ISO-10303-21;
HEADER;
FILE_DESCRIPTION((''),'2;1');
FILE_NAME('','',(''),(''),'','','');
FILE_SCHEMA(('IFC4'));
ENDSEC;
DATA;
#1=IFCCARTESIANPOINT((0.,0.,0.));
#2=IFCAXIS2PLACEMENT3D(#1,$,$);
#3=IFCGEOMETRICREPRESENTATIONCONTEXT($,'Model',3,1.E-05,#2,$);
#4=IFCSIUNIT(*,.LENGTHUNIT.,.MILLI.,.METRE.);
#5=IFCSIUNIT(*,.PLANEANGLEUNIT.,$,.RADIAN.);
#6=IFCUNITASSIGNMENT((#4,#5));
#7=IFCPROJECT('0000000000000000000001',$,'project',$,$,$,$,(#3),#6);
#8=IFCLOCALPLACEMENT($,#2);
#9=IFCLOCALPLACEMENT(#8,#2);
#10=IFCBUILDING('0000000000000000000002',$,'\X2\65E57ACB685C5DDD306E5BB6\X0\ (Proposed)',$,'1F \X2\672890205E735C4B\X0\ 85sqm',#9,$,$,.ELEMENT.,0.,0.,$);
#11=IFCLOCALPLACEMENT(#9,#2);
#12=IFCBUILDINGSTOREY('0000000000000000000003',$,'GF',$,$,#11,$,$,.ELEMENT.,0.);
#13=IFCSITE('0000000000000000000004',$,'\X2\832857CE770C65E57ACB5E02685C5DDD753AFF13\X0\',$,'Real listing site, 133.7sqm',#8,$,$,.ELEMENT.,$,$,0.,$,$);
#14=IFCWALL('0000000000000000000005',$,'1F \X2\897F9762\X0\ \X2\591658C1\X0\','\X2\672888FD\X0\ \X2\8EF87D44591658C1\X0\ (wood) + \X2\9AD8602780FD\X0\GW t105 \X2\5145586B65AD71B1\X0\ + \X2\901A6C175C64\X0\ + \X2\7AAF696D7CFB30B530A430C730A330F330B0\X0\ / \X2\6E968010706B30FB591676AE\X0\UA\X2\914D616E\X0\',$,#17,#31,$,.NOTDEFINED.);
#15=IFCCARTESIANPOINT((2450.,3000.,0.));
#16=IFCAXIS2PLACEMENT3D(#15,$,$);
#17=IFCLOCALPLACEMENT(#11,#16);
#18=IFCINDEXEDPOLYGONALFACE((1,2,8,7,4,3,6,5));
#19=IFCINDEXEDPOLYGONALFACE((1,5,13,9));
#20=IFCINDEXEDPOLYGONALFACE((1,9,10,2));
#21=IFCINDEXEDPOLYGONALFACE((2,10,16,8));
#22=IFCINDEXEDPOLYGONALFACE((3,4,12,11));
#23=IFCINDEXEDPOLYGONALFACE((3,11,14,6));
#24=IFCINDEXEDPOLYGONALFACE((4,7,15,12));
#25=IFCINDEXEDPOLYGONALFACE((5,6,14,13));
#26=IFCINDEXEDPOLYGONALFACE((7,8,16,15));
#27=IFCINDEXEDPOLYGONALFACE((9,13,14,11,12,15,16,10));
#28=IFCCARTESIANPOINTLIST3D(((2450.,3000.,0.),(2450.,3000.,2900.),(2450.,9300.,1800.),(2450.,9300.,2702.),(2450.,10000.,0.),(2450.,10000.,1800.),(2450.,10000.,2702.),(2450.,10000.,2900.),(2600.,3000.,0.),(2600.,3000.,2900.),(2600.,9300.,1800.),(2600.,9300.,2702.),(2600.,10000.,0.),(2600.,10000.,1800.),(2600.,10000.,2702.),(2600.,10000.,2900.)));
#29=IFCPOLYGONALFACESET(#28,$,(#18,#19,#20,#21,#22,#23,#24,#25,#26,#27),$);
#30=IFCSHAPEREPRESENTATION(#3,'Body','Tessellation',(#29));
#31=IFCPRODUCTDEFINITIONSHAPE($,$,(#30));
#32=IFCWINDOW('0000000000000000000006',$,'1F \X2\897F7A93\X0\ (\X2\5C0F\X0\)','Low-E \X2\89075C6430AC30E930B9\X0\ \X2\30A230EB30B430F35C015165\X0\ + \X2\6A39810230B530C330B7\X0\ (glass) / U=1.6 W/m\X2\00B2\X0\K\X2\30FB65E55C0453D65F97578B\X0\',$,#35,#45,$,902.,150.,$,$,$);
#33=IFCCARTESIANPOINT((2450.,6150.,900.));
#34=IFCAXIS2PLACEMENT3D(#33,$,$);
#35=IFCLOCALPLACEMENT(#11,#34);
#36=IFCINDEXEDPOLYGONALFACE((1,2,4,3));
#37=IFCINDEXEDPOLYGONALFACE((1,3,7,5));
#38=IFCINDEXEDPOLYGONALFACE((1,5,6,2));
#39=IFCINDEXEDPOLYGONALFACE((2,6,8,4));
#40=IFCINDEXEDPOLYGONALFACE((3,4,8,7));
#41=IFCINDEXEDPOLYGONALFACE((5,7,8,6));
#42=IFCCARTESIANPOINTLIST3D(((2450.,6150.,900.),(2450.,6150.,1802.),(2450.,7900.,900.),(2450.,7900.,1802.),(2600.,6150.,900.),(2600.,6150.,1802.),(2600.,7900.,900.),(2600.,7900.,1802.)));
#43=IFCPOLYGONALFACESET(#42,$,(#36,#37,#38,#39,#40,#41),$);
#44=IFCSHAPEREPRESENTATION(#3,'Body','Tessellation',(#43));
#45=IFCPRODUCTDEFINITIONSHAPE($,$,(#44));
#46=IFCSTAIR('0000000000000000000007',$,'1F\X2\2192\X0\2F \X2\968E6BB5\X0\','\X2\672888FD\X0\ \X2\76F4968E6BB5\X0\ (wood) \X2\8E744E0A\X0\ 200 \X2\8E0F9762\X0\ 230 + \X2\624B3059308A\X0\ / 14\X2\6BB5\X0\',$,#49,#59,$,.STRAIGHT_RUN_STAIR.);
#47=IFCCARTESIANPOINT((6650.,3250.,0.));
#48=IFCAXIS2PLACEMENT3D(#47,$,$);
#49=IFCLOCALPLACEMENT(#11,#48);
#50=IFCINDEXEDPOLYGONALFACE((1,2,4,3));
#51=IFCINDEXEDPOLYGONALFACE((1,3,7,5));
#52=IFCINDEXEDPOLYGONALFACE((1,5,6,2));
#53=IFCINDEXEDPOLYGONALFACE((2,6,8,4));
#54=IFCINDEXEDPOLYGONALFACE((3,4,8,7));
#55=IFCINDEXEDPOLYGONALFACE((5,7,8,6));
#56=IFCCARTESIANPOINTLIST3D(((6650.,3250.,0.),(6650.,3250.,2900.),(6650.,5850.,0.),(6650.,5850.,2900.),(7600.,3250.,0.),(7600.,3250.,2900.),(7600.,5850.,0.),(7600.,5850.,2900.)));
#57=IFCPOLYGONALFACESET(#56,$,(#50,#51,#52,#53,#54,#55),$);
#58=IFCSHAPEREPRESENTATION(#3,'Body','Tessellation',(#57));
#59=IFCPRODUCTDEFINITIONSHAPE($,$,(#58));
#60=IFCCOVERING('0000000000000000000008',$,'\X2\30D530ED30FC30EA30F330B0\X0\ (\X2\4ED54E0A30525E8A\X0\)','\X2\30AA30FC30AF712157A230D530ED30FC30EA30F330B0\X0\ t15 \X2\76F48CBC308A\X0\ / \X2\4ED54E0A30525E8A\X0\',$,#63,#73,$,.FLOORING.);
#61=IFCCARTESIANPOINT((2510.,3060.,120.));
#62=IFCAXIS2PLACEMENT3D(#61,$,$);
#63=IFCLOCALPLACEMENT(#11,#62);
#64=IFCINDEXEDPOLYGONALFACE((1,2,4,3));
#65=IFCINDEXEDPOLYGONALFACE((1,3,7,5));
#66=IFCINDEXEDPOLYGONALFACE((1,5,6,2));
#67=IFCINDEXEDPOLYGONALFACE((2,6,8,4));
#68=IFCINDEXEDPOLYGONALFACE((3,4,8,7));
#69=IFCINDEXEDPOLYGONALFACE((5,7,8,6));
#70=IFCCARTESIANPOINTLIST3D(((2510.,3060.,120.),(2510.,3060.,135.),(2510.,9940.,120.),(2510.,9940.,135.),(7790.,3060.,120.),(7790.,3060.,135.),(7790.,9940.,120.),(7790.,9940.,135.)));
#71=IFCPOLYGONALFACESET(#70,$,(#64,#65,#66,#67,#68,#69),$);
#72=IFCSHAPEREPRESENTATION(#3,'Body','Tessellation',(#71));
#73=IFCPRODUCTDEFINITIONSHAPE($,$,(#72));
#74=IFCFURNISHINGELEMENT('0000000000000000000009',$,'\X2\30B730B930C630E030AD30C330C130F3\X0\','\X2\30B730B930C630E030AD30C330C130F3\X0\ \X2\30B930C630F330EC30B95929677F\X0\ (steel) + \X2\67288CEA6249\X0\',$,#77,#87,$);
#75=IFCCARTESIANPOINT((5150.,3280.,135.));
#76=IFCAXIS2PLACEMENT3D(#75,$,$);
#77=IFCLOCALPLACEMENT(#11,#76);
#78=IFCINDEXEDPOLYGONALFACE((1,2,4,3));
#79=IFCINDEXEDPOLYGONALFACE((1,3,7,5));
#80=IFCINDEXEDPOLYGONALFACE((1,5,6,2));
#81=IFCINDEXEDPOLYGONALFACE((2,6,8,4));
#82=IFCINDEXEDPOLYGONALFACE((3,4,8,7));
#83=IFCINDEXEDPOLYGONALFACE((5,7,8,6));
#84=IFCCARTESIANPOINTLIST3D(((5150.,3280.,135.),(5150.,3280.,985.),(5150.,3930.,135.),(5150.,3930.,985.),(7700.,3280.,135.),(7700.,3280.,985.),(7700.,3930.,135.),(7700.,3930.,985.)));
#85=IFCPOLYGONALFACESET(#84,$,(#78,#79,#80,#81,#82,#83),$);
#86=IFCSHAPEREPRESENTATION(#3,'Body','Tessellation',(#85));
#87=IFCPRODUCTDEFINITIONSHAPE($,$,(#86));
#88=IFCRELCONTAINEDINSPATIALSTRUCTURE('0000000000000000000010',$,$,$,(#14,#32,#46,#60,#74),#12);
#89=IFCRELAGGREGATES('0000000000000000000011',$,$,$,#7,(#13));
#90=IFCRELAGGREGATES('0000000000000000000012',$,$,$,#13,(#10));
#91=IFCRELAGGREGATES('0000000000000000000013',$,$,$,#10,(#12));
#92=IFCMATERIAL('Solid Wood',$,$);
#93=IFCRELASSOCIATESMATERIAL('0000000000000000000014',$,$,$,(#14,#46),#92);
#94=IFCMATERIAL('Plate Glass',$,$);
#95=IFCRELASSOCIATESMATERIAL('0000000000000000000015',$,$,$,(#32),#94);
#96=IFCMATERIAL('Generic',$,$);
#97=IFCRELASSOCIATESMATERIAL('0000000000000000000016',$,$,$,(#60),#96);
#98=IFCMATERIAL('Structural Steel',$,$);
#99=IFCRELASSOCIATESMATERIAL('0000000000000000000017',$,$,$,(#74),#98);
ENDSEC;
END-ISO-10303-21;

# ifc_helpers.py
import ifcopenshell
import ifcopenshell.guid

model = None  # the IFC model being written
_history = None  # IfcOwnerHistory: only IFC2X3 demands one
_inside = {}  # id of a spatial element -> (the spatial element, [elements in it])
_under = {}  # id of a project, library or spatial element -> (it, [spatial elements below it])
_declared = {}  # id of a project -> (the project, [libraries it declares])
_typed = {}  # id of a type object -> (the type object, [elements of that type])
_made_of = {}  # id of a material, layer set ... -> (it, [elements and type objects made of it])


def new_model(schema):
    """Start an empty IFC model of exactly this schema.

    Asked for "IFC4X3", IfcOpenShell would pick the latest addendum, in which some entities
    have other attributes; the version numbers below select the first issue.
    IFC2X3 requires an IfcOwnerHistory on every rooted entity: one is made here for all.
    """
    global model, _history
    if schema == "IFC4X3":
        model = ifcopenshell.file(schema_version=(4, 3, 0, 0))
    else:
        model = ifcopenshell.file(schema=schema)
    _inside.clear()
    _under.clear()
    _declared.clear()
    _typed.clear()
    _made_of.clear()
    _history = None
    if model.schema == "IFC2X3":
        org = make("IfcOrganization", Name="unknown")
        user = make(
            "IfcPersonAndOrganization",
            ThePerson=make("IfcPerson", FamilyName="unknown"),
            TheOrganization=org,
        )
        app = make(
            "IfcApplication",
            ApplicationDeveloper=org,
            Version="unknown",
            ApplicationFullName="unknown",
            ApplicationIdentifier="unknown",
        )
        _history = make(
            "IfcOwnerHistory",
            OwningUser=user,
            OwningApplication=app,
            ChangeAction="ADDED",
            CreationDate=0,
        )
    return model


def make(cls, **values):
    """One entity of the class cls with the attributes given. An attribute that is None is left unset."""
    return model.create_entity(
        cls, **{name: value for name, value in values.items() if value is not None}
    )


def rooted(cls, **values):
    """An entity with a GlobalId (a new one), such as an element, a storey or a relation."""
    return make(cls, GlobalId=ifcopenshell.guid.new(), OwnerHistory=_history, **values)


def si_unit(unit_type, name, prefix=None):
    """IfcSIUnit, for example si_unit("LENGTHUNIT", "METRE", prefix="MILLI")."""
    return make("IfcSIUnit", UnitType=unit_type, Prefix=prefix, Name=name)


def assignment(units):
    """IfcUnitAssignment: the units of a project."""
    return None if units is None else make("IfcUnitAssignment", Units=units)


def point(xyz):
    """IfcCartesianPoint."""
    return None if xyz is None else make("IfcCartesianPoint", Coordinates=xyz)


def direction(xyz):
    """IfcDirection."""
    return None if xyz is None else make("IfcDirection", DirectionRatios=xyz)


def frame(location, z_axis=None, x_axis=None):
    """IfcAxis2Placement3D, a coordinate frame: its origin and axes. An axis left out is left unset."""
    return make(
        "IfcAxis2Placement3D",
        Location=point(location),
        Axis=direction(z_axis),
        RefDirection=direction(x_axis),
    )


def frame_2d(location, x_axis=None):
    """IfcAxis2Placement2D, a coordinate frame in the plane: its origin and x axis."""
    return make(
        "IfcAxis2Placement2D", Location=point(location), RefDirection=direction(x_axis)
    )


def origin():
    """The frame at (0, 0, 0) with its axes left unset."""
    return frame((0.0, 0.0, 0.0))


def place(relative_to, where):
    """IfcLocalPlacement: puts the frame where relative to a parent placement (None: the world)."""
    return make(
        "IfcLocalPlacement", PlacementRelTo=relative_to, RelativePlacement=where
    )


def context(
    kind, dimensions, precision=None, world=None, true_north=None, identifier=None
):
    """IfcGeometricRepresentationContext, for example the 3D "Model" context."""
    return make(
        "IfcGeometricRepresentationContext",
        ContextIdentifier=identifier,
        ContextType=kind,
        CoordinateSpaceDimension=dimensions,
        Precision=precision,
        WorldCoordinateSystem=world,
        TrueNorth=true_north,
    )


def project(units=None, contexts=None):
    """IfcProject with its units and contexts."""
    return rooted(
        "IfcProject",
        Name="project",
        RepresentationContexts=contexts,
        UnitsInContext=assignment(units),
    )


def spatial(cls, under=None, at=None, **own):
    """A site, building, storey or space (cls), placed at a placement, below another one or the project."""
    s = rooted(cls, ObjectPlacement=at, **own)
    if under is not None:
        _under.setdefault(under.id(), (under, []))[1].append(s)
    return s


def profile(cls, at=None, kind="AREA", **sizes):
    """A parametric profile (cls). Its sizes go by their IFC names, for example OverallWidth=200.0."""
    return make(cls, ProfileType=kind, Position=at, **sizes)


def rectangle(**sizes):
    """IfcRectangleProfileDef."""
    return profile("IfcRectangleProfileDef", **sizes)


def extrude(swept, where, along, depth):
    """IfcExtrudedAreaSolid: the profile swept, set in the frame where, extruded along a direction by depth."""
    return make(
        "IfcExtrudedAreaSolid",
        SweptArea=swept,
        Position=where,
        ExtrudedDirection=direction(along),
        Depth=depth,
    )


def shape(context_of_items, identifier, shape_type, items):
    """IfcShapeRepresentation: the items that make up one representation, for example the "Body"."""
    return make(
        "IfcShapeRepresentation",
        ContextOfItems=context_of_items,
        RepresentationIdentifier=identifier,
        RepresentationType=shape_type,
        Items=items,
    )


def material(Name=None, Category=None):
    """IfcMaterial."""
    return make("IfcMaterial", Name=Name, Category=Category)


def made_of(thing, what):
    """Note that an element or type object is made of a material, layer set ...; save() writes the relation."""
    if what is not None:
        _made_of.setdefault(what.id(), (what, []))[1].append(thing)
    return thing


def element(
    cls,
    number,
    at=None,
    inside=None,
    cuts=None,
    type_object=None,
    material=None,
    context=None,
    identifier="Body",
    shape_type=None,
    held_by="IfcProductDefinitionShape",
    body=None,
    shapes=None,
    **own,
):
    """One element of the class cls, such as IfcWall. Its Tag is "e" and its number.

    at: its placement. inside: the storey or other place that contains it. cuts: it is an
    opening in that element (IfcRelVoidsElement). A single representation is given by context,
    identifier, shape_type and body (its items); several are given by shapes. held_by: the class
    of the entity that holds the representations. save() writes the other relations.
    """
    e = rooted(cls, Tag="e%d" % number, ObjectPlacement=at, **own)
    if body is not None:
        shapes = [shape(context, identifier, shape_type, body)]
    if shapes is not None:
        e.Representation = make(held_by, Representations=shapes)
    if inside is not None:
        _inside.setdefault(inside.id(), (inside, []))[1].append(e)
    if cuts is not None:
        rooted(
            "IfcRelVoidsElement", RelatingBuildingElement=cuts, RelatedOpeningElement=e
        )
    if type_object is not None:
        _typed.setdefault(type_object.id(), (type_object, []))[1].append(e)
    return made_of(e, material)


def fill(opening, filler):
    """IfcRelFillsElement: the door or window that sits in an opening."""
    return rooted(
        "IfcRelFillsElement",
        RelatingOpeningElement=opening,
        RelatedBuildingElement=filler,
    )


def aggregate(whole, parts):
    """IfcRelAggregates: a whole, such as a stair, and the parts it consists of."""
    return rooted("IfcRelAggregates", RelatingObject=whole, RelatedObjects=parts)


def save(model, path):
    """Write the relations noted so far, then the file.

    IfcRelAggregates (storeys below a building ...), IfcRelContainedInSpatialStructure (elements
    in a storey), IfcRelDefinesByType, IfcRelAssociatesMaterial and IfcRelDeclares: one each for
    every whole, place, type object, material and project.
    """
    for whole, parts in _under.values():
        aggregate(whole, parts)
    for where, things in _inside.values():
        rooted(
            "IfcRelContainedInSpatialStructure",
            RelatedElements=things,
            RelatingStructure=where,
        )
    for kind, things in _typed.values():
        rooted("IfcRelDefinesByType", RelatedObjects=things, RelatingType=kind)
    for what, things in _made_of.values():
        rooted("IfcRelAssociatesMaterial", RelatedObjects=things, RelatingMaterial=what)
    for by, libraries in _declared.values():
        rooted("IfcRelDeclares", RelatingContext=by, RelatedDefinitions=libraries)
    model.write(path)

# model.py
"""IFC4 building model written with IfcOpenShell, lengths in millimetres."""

from ifc_helpers import new_model, si_unit, frame, frame_2d, origin, place, context, project, spatial, rectangle, extrude, material, element, fill, save


model = new_model("IFC4")

# Units and contexts
model_context = context("Model", 3, precision=1e-05, world=origin())
ifc_project = project(units=[si_unit("LENGTHUNIT", "METRE", prefix="MILLI"), si_unit("PLANEANGLEUNIT", "RADIAN")], contexts=[model_context])

# Site, building, storey
site_placement = place(None, origin())
site = spatial("IfcSite", under=ifc_project, at=site_placement, Name="茨城県日立市桜川町３", ObjectType="Real listing site, 133.7sqm", CompositionType="ELEMENT", RefElevation=0.0)
building_placement = place(site_placement, origin())
building = spatial("IfcBuilding", under=site, at=building_placement, Name="日立桜川の家 (Proposed)", ObjectType="1F 木造平屋 85sqm", CompositionType="ELEMENT", ElevationOfRefHeight=0.0, ElevationOfTerrain=0.0)
storey_placement = place(building_placement, origin())
storey = spatial("IfcBuildingStorey", under=building, at=storey_placement, Name="GF", CompositionType="ELEMENT", Elevation=0.0)

# Shared definitions
ifc_material_1 = material(Name="Solid Wood")
ifc_material_2 = material(Name="Generic")

# Shared definitions
ifc_material_3 = material(Name="Plate Glass")

# Wall, opening, window
wall_1_placement = place(storey_placement, frame((2450.0, 3000.0, 0.0)))
wall_1 = element("IfcWall", 1, at=wall_1_placement, inside=storey, material=ifc_material_1, Name="1F 西面 外壁", Description="木製 軸組外壁 (wood) + 高性能GW t105 充填断熱 + 通気層 + 窯業系サイディング / 準耐火・外皮UA配慮", PredefinedType="NOTDEFINED", context=model_context, shape_type="SweptSolid", body=[
    extrude(rectangle(XDim=150.0, YDim=7000.0, at=frame_2d((75.0, 3500.0))), frame((2450.0, 3000.0, 0.0)), (0.0, 0.0, 1.0), 2900.0),
])
opening_1_placement = place(storey_placement, frame((2450.0, 6150.0, 900.0)))
opening_1 = element("IfcOpeningElement", 2, at=opening_1_placement, cuts=wall_1, PredefinedType="NOTDEFINED", context=model_context, shape_type="SweptSolid", body=[
    extrude(rectangle(XDim=150.0, YDim=1750.0, at=frame_2d((75.0, 875.0))), frame((2450.0, 6150.0, 900.0)), (0.0, 0.0, 1.0), 902.0),
])
window_1_placement = place(storey_placement, frame((2450.0, 6150.0, 900.0)))
window_1 = element("IfcWindow", 3, at=window_1_placement, inside=storey, material=ifc_material_3, Name="1F 西窓 (小)", Description="Low-E 複層ガラス アルゴン封入 + 樹脂サッシ (glass) / U=1.6 W/m²K・日射取得型", OverallHeight=902.0, OverallWidth=150.0, context=model_context, shape_type="SweptSolid", body=[
    extrude(rectangle(XDim=150.0, YDim=1750.0, at=frame_2d((75.0, 875.0))), frame((2450.0, 6150.0, 900.0)), (0.0, 0.0, 1.0), 902.0),
])
fill(opening_1, window_1)

# Stair
stair_placement = place(storey_placement, frame((6650.0, 3250.0, 0.0)))
element("IfcStair", 4, at=stair_placement, inside=storey, material=ifc_material_1, Name="1F→2F 階段", Description="木製 直階段 (wood) 蹴上 200 踏面 230 + 手すり / 14段", PredefinedType="STRAIGHT_RUN_STAIR", context=model_context, shape_type="SweptSolid", body=[
    extrude(rectangle(XDim=950.0, YDim=2600.0, at=frame_2d((475.0, 1300.0))), frame((6650.0, 3250.0, 0.0)), (0.0, 0.0, 1.0), 2900.0),
])

# Covering
covering_placement = place(storey_placement, frame((2510.0, 3060.0, 120.0)))
element("IfcCovering", 5, at=covering_placement, inside=storey, material=ifc_material_2, Name="フローリング (仕上げ床)", Description="オーク無垢フローリング t15 直貼り / 仕上げ床", PredefinedType="FLOORING", context=model_context, shape_type="SweptSolid", body=[
    extrude(rectangle(XDim=5280.0, YDim=6880.0, at=frame_2d((2640.0, 3440.0))), frame((2510.0, 3060.0, 120.0)), (0.0, 0.0, 1.0), 15.0),
])

# Furnishing element
ifc_material_4 = material(Name="Structural Steel")
furnishing_placement = place(storey_placement, frame((5150.0, 3280.0, 135.0)))
element("IfcFurnishingElement", 6, at=furnishing_placement, inside=storey, material=ifc_material_4, Name="システムキッチン", Description="システムキッチン ステンレス天板 (steel) + 木質扉", context=model_context, shape_type="SweptSolid", body=[
    extrude(rectangle(XDim=2550.0, YDim=650.0, at=frame_2d((1275.0, 325.0))), frame((5150.0, 3280.0, 135.0)), (0.0, 0.0, 1.0), 850.0),
])

save(model, "model.ifc")
